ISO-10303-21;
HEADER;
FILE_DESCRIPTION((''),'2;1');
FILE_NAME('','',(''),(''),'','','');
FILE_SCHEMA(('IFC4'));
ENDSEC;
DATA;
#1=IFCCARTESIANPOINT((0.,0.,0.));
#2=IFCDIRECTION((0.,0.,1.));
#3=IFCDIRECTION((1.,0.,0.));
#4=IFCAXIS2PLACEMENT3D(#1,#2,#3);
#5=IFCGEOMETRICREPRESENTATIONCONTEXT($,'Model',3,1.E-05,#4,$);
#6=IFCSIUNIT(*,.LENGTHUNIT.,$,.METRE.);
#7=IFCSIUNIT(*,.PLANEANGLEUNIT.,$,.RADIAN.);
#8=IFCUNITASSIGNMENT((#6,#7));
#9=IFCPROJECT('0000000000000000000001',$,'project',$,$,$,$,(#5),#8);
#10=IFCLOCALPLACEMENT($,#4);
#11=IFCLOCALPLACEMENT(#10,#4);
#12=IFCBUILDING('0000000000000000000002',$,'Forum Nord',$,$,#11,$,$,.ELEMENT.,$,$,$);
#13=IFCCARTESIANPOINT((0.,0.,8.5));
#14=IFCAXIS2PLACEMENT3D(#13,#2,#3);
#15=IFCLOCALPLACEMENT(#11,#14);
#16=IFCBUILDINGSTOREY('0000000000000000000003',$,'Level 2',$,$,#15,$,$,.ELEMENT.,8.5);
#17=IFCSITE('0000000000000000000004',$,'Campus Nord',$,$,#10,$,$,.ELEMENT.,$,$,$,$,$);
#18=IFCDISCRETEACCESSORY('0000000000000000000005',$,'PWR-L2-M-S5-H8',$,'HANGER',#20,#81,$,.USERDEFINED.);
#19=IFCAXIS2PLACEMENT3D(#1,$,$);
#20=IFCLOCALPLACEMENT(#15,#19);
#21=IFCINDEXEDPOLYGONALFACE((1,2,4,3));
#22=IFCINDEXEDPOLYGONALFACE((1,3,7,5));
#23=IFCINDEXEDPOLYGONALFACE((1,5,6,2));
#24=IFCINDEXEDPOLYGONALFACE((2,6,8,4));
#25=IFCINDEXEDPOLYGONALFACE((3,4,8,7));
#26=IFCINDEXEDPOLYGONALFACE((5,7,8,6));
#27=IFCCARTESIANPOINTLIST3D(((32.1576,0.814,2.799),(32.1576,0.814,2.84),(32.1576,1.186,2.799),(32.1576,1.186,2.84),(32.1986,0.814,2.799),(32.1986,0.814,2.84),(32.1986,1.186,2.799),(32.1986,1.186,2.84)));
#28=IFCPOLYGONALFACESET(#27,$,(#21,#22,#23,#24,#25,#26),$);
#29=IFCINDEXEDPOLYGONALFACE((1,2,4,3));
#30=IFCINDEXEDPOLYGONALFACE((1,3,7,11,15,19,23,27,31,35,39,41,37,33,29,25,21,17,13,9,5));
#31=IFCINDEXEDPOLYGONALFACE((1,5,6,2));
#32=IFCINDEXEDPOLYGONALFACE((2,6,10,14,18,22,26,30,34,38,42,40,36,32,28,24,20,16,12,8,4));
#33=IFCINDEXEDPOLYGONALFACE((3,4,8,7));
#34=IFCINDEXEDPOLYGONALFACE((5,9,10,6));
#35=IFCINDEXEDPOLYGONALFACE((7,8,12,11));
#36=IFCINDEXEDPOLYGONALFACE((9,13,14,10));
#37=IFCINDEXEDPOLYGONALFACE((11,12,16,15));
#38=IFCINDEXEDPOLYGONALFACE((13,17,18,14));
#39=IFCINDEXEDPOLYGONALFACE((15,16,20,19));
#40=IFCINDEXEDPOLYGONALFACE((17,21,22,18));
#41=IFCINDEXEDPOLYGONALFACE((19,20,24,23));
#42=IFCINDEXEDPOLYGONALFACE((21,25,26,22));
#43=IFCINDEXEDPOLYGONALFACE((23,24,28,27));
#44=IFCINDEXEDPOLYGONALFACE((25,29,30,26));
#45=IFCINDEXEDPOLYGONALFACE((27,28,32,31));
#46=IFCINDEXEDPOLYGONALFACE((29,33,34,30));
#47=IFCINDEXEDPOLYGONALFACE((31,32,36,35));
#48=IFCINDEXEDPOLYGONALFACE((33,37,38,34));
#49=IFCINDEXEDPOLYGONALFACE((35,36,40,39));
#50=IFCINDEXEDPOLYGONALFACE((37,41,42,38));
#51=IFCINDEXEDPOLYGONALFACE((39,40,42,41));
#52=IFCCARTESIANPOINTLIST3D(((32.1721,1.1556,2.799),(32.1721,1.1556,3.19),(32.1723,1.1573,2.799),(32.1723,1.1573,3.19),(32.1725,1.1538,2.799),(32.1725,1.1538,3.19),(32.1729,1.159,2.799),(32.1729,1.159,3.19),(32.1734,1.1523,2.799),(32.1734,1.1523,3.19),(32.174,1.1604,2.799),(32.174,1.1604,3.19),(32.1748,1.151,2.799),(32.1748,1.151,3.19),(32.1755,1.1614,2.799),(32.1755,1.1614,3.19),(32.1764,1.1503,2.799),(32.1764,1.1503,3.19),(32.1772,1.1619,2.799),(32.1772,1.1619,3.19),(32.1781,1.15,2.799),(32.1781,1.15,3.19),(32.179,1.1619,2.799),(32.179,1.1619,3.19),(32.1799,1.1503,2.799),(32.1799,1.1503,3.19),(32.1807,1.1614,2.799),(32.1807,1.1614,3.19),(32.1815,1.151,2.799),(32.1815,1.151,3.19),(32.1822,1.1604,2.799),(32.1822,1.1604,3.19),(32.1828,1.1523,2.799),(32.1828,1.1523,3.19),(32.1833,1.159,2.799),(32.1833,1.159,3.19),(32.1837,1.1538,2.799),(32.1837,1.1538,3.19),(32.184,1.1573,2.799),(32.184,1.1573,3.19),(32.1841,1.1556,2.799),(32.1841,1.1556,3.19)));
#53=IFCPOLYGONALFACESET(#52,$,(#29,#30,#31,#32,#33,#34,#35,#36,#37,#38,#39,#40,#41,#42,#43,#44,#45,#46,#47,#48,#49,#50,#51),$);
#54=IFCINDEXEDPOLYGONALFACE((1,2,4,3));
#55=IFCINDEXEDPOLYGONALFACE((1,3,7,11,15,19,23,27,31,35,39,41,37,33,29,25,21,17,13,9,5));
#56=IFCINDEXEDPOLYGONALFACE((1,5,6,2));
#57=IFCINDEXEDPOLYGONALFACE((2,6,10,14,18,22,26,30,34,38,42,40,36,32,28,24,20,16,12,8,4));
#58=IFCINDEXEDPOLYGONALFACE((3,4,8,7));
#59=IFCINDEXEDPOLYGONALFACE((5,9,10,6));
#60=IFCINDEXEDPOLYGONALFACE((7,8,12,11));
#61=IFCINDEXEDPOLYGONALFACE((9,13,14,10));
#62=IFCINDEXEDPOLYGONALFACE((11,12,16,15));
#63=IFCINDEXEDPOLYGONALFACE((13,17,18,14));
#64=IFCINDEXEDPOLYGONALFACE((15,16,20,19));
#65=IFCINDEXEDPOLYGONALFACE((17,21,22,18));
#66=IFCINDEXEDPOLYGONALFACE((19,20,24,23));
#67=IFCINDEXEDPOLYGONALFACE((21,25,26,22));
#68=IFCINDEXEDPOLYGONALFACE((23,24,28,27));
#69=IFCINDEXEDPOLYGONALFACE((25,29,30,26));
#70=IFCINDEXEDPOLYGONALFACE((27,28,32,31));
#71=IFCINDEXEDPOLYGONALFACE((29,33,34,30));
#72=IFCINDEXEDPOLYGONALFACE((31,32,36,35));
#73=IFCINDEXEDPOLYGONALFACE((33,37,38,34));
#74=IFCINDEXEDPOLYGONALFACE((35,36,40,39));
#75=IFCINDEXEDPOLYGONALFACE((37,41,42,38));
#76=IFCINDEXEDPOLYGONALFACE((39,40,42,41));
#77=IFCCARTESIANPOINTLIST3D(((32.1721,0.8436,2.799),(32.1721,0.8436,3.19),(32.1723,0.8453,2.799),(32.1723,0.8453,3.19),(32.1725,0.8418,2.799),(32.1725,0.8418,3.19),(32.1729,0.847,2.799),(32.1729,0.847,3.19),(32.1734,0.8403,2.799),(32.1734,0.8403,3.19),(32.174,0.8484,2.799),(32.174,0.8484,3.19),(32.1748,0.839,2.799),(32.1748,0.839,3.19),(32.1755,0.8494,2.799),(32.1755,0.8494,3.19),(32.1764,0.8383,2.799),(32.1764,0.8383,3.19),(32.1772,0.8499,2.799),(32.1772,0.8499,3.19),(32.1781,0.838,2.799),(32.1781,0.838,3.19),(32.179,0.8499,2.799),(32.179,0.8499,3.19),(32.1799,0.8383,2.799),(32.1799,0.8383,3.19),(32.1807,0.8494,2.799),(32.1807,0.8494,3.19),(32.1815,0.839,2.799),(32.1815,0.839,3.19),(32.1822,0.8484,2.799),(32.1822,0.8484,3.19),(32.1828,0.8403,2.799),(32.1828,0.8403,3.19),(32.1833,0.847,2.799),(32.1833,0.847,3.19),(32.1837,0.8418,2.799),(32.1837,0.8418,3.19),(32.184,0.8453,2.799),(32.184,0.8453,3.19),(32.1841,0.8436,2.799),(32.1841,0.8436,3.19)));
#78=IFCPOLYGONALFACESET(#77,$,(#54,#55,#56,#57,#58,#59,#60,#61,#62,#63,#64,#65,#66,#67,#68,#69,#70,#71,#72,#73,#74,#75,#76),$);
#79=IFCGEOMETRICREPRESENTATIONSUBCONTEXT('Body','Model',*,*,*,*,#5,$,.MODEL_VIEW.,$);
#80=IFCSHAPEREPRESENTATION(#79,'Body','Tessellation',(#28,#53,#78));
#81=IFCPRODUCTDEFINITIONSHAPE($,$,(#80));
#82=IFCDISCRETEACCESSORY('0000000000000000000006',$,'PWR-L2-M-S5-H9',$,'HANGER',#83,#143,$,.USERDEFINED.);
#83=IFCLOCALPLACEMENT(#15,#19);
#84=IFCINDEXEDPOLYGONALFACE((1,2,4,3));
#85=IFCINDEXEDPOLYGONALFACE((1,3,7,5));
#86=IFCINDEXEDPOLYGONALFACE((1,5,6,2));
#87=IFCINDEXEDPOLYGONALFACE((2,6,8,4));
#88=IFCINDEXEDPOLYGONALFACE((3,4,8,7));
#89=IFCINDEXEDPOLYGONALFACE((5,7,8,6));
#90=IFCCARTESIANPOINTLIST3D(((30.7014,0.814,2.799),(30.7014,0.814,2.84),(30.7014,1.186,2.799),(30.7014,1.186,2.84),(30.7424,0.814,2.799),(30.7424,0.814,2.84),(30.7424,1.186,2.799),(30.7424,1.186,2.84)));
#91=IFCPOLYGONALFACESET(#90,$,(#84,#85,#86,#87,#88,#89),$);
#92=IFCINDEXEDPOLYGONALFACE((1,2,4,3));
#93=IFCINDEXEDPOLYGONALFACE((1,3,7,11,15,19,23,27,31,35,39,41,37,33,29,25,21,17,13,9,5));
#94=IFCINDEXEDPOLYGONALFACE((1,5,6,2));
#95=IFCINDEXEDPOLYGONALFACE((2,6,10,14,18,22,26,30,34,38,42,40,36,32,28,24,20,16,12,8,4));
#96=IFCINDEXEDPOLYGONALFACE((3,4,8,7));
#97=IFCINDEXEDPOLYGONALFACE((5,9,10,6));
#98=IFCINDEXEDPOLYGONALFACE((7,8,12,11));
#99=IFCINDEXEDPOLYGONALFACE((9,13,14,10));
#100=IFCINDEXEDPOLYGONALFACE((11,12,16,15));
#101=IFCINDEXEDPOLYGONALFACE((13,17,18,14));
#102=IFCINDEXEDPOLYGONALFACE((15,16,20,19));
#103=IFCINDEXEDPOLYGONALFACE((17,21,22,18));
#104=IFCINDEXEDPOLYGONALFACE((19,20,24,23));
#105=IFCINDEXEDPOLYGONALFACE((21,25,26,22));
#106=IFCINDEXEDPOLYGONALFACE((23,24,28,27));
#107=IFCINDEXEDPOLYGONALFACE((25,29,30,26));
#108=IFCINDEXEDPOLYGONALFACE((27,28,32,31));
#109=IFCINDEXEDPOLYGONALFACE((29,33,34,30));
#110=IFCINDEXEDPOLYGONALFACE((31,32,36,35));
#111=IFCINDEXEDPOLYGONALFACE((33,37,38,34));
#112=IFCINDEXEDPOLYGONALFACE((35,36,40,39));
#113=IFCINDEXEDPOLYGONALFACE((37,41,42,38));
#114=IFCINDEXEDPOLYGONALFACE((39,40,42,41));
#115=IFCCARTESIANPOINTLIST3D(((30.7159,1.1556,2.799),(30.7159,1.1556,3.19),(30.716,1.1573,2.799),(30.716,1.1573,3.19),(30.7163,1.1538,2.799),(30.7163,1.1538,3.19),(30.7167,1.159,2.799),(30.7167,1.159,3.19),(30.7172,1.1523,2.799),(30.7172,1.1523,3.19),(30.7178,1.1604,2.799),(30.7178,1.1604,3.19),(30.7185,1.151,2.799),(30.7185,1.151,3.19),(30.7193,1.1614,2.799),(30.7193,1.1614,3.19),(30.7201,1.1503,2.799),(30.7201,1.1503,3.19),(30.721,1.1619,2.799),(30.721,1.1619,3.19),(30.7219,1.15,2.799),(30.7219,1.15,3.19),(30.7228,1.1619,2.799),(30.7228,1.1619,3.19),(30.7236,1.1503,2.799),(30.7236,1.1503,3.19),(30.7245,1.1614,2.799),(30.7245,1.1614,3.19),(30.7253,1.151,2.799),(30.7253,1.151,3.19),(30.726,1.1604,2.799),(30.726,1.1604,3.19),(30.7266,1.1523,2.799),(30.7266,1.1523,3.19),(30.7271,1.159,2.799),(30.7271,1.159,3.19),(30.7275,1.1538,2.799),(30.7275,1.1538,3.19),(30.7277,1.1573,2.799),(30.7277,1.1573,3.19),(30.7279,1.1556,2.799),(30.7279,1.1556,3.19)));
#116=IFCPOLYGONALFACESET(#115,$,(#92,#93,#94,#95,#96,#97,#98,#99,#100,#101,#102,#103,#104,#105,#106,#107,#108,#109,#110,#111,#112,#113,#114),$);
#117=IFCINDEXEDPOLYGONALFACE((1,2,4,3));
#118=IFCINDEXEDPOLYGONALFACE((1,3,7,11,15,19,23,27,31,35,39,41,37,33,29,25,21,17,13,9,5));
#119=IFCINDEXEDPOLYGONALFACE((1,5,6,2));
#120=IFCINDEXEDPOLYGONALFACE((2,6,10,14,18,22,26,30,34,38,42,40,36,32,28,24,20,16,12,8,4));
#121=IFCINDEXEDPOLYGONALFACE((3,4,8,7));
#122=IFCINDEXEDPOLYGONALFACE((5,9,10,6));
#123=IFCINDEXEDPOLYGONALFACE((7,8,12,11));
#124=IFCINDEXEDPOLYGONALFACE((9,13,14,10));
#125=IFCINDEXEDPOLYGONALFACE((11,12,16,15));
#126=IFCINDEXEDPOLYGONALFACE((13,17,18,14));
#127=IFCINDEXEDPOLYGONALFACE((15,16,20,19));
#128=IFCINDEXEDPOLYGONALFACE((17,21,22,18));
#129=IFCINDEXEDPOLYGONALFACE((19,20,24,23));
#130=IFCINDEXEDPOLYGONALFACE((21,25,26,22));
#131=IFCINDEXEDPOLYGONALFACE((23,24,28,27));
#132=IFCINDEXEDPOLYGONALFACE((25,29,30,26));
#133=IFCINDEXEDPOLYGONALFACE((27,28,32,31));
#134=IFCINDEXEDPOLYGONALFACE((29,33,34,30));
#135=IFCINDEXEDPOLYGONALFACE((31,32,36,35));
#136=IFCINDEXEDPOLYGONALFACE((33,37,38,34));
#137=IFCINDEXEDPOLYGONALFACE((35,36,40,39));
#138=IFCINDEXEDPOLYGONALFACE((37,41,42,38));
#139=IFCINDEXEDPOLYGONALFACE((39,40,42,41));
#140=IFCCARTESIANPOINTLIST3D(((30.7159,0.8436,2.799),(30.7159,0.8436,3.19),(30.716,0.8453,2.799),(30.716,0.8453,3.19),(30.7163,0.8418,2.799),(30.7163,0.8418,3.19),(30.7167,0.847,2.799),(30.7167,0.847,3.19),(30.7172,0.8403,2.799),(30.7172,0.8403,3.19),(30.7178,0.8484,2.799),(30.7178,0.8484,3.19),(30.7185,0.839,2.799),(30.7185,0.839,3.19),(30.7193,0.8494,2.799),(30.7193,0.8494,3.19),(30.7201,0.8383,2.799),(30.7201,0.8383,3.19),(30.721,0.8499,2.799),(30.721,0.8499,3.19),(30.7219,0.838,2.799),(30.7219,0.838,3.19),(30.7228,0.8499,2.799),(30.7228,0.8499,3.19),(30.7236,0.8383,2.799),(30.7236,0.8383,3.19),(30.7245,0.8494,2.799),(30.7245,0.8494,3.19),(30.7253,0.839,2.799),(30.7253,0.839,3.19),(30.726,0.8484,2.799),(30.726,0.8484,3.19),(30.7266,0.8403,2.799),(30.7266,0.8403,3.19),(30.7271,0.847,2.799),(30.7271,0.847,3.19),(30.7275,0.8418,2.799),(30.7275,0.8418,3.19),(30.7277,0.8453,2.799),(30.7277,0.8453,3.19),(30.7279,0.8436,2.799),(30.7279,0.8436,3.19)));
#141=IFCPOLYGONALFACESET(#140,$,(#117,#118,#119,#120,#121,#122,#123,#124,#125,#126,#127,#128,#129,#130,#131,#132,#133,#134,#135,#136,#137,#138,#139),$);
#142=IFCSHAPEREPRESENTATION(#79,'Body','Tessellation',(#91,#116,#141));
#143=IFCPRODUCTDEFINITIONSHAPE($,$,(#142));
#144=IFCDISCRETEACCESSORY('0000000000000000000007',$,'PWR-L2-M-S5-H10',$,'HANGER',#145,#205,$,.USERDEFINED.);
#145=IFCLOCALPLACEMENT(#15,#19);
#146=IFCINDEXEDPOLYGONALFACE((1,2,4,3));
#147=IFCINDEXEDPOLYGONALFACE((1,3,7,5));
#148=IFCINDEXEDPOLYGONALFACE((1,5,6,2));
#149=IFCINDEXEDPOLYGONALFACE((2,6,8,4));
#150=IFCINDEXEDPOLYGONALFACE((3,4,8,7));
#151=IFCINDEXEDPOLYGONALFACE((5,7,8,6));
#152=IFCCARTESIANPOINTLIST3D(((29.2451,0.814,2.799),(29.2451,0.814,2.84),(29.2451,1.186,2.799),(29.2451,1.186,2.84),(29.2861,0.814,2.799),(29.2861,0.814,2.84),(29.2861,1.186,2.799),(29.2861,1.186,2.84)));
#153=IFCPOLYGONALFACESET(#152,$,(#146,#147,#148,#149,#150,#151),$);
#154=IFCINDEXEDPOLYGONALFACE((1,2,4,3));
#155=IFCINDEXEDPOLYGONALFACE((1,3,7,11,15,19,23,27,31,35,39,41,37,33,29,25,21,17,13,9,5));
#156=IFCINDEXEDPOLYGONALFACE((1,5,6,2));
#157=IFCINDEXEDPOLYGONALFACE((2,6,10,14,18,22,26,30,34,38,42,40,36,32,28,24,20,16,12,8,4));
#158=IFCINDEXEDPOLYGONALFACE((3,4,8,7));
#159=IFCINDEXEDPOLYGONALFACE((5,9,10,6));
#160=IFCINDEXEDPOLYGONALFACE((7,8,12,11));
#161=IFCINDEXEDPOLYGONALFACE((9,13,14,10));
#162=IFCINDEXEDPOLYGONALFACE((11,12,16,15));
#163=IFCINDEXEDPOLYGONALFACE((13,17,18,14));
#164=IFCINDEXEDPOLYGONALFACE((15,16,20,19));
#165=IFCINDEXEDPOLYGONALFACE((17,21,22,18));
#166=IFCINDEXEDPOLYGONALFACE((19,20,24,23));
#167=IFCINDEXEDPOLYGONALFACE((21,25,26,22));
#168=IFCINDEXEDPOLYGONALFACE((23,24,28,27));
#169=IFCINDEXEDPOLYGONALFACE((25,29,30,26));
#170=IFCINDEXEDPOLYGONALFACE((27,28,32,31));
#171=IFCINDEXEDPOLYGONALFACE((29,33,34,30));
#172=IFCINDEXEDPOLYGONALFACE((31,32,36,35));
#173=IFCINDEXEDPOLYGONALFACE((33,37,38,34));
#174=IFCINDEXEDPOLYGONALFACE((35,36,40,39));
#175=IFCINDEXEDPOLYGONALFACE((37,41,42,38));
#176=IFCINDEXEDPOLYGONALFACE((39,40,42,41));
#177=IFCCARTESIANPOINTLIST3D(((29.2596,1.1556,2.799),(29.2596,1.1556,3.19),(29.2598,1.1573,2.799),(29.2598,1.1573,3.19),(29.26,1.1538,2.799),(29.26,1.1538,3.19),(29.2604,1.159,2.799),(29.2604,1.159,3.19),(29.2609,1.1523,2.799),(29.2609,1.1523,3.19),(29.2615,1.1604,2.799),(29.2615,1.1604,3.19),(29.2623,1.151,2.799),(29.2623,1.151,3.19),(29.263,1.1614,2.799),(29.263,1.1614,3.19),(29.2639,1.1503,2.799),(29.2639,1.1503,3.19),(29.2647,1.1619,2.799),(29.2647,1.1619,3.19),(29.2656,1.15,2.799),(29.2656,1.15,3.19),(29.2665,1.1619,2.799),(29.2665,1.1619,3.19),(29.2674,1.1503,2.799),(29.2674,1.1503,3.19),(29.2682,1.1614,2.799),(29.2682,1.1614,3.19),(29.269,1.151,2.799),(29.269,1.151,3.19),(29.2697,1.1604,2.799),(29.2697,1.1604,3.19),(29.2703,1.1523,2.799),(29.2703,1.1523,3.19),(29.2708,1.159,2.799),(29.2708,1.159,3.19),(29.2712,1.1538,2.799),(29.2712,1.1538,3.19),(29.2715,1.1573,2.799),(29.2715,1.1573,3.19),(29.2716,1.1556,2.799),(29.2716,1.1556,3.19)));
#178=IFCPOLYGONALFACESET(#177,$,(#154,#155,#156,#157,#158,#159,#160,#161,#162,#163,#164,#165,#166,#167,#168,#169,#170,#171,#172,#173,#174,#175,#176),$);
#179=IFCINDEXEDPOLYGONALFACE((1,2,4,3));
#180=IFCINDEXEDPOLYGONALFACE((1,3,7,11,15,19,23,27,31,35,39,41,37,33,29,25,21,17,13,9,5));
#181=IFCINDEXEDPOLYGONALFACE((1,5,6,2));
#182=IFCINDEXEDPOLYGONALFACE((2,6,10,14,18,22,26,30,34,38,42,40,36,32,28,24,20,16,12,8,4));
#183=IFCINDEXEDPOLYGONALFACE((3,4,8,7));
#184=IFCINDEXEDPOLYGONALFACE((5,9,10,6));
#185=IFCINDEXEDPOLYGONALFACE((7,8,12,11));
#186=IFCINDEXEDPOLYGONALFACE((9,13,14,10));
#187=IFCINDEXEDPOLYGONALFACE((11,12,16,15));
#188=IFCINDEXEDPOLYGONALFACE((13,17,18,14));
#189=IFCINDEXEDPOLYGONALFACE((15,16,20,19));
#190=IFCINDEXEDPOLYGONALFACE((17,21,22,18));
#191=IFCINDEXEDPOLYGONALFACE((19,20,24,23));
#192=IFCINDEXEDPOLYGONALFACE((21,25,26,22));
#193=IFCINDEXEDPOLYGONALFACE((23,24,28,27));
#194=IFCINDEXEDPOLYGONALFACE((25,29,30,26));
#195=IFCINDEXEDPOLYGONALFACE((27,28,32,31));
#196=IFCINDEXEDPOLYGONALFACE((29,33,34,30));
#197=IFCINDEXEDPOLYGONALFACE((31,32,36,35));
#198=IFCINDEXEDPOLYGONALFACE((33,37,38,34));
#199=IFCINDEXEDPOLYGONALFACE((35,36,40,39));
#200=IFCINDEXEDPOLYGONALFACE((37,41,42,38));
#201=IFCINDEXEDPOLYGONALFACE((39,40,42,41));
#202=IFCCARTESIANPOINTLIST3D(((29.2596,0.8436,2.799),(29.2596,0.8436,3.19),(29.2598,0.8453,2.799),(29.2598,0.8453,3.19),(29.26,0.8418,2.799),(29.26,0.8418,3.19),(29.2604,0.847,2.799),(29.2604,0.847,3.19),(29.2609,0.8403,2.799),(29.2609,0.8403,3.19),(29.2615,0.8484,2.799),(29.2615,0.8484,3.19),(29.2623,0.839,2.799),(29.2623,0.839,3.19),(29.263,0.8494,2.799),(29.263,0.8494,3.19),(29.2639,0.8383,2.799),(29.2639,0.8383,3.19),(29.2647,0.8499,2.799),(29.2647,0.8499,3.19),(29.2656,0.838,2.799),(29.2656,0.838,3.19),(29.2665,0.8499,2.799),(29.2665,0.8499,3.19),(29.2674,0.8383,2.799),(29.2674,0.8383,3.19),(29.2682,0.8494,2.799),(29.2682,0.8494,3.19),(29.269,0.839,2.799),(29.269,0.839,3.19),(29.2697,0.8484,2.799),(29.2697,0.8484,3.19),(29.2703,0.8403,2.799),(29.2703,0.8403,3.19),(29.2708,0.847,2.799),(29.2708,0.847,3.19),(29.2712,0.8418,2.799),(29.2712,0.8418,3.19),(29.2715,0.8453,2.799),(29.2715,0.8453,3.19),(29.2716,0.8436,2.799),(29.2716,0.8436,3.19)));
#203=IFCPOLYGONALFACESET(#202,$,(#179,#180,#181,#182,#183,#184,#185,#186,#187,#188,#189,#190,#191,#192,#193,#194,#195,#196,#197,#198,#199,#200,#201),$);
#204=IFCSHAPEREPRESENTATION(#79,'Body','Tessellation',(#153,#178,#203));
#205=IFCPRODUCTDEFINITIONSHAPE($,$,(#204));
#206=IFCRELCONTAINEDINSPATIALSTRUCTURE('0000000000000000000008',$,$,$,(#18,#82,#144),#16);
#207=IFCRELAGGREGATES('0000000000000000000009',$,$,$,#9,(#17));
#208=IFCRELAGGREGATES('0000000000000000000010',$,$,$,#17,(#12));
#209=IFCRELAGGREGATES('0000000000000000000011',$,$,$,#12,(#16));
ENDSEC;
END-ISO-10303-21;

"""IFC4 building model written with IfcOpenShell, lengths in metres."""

from ifc_helpers import new_model, si_unit, frame, frame_2d, origin_with_axes, origin_2d_with_axis, place, context, subcontext, project, spatial, rectangle, circle, extrude, element, save


model = new_model("IFC4")

# Units and contexts
model_context = context("Model", 3, precision=1e-05, world=origin_with_axes())
body_context = subcontext(model_context, "Body", "Model", "MODEL_VIEW")
ifc_project = project(units=[si_unit("LENGTHUNIT", "METRE"), si_unit("PLANEANGLEUNIT", "RADIAN")], contexts=[model_context])

# Site, building, storey
site_placement = place(None, origin_with_axes())
site = spatial("IfcSite", under=ifc_project, at=site_placement, Name="Campus Nord", CompositionType="ELEMENT")
building_placement = place(site_placement, origin_with_axes())
building = spatial("IfcBuilding", under=site, at=building_placement, Name="Forum Nord", CompositionType="ELEMENT")
storey_placement = place(building_placement, frame((0.0, 0.0, 8.5), z_axis=(0.0, 0.0, 1.0), x_axis=(1.0, 0.0, 0.0)))
storey = spatial("IfcBuildingStorey", under=building, at=storey_placement, Name="Level 2", CompositionType="ELEMENT", Elevation=8.5)

# Discrete accessories
for number, where, z_axis, x_axis, name in (
    (1, (32.1781, 1.0, 2.84), (0.0, 0.0, 1.0), (0.0, -1.0, 0.0), "PWR-L2-M-S5-H8"),
    (2, (30.7219, 1.0, 2.84), (0.0, 0.0, 1.0), (0.0, -1.0, 0.0), "PWR-L2-M-S5-H9"),
    (3, (29.2656, 1.0, 2.84), (0.0, 0.0, 1.0), (0.0, -1.0, 0.0), "PWR-L2-M-S5-H10"),
):
    element("IfcDiscreteAccessory", number, at=place(storey_placement, frame(where, z_axis=z_axis, x_axis=x_axis)), inside=storey, Name=name, ObjectType="HANGER", PredefinedType="USERDEFINED", context=body_context, shape_type="SweptSolid", body=[
        extrude(rectangle(XDim=0.372, YDim=0.041, at=origin_2d_with_axis()), frame((0.0, 0.0, -0.041), z_axis=(0.0, 0.0, 1.0), x_axis=(1.0, 0.0, 0.0)), (0.0, 0.0, 1.0), 0.041),
        extrude(circle(Radius=0.006, at=frame_2d((-0.156, 0.0), x_axis=(1.0, 0.0))), frame((0.0, 0.0, -0.041), z_axis=(0.0, 0.0, 1.0), x_axis=(1.0, 0.0, 0.0)), (0.0, 0.0, 1.0), 0.391),
        extrude(circle(Radius=0.006, at=frame_2d((0.156, 0.0), x_axis=(1.0, 0.0))), frame((0.0, 0.0, -0.041), z_axis=(0.0, 0.0, 1.0), x_axis=(1.0, 0.0, 0.0)), (0.0, 0.0, 1.0), 0.391),
    ])

save(model, "model.ifc")
